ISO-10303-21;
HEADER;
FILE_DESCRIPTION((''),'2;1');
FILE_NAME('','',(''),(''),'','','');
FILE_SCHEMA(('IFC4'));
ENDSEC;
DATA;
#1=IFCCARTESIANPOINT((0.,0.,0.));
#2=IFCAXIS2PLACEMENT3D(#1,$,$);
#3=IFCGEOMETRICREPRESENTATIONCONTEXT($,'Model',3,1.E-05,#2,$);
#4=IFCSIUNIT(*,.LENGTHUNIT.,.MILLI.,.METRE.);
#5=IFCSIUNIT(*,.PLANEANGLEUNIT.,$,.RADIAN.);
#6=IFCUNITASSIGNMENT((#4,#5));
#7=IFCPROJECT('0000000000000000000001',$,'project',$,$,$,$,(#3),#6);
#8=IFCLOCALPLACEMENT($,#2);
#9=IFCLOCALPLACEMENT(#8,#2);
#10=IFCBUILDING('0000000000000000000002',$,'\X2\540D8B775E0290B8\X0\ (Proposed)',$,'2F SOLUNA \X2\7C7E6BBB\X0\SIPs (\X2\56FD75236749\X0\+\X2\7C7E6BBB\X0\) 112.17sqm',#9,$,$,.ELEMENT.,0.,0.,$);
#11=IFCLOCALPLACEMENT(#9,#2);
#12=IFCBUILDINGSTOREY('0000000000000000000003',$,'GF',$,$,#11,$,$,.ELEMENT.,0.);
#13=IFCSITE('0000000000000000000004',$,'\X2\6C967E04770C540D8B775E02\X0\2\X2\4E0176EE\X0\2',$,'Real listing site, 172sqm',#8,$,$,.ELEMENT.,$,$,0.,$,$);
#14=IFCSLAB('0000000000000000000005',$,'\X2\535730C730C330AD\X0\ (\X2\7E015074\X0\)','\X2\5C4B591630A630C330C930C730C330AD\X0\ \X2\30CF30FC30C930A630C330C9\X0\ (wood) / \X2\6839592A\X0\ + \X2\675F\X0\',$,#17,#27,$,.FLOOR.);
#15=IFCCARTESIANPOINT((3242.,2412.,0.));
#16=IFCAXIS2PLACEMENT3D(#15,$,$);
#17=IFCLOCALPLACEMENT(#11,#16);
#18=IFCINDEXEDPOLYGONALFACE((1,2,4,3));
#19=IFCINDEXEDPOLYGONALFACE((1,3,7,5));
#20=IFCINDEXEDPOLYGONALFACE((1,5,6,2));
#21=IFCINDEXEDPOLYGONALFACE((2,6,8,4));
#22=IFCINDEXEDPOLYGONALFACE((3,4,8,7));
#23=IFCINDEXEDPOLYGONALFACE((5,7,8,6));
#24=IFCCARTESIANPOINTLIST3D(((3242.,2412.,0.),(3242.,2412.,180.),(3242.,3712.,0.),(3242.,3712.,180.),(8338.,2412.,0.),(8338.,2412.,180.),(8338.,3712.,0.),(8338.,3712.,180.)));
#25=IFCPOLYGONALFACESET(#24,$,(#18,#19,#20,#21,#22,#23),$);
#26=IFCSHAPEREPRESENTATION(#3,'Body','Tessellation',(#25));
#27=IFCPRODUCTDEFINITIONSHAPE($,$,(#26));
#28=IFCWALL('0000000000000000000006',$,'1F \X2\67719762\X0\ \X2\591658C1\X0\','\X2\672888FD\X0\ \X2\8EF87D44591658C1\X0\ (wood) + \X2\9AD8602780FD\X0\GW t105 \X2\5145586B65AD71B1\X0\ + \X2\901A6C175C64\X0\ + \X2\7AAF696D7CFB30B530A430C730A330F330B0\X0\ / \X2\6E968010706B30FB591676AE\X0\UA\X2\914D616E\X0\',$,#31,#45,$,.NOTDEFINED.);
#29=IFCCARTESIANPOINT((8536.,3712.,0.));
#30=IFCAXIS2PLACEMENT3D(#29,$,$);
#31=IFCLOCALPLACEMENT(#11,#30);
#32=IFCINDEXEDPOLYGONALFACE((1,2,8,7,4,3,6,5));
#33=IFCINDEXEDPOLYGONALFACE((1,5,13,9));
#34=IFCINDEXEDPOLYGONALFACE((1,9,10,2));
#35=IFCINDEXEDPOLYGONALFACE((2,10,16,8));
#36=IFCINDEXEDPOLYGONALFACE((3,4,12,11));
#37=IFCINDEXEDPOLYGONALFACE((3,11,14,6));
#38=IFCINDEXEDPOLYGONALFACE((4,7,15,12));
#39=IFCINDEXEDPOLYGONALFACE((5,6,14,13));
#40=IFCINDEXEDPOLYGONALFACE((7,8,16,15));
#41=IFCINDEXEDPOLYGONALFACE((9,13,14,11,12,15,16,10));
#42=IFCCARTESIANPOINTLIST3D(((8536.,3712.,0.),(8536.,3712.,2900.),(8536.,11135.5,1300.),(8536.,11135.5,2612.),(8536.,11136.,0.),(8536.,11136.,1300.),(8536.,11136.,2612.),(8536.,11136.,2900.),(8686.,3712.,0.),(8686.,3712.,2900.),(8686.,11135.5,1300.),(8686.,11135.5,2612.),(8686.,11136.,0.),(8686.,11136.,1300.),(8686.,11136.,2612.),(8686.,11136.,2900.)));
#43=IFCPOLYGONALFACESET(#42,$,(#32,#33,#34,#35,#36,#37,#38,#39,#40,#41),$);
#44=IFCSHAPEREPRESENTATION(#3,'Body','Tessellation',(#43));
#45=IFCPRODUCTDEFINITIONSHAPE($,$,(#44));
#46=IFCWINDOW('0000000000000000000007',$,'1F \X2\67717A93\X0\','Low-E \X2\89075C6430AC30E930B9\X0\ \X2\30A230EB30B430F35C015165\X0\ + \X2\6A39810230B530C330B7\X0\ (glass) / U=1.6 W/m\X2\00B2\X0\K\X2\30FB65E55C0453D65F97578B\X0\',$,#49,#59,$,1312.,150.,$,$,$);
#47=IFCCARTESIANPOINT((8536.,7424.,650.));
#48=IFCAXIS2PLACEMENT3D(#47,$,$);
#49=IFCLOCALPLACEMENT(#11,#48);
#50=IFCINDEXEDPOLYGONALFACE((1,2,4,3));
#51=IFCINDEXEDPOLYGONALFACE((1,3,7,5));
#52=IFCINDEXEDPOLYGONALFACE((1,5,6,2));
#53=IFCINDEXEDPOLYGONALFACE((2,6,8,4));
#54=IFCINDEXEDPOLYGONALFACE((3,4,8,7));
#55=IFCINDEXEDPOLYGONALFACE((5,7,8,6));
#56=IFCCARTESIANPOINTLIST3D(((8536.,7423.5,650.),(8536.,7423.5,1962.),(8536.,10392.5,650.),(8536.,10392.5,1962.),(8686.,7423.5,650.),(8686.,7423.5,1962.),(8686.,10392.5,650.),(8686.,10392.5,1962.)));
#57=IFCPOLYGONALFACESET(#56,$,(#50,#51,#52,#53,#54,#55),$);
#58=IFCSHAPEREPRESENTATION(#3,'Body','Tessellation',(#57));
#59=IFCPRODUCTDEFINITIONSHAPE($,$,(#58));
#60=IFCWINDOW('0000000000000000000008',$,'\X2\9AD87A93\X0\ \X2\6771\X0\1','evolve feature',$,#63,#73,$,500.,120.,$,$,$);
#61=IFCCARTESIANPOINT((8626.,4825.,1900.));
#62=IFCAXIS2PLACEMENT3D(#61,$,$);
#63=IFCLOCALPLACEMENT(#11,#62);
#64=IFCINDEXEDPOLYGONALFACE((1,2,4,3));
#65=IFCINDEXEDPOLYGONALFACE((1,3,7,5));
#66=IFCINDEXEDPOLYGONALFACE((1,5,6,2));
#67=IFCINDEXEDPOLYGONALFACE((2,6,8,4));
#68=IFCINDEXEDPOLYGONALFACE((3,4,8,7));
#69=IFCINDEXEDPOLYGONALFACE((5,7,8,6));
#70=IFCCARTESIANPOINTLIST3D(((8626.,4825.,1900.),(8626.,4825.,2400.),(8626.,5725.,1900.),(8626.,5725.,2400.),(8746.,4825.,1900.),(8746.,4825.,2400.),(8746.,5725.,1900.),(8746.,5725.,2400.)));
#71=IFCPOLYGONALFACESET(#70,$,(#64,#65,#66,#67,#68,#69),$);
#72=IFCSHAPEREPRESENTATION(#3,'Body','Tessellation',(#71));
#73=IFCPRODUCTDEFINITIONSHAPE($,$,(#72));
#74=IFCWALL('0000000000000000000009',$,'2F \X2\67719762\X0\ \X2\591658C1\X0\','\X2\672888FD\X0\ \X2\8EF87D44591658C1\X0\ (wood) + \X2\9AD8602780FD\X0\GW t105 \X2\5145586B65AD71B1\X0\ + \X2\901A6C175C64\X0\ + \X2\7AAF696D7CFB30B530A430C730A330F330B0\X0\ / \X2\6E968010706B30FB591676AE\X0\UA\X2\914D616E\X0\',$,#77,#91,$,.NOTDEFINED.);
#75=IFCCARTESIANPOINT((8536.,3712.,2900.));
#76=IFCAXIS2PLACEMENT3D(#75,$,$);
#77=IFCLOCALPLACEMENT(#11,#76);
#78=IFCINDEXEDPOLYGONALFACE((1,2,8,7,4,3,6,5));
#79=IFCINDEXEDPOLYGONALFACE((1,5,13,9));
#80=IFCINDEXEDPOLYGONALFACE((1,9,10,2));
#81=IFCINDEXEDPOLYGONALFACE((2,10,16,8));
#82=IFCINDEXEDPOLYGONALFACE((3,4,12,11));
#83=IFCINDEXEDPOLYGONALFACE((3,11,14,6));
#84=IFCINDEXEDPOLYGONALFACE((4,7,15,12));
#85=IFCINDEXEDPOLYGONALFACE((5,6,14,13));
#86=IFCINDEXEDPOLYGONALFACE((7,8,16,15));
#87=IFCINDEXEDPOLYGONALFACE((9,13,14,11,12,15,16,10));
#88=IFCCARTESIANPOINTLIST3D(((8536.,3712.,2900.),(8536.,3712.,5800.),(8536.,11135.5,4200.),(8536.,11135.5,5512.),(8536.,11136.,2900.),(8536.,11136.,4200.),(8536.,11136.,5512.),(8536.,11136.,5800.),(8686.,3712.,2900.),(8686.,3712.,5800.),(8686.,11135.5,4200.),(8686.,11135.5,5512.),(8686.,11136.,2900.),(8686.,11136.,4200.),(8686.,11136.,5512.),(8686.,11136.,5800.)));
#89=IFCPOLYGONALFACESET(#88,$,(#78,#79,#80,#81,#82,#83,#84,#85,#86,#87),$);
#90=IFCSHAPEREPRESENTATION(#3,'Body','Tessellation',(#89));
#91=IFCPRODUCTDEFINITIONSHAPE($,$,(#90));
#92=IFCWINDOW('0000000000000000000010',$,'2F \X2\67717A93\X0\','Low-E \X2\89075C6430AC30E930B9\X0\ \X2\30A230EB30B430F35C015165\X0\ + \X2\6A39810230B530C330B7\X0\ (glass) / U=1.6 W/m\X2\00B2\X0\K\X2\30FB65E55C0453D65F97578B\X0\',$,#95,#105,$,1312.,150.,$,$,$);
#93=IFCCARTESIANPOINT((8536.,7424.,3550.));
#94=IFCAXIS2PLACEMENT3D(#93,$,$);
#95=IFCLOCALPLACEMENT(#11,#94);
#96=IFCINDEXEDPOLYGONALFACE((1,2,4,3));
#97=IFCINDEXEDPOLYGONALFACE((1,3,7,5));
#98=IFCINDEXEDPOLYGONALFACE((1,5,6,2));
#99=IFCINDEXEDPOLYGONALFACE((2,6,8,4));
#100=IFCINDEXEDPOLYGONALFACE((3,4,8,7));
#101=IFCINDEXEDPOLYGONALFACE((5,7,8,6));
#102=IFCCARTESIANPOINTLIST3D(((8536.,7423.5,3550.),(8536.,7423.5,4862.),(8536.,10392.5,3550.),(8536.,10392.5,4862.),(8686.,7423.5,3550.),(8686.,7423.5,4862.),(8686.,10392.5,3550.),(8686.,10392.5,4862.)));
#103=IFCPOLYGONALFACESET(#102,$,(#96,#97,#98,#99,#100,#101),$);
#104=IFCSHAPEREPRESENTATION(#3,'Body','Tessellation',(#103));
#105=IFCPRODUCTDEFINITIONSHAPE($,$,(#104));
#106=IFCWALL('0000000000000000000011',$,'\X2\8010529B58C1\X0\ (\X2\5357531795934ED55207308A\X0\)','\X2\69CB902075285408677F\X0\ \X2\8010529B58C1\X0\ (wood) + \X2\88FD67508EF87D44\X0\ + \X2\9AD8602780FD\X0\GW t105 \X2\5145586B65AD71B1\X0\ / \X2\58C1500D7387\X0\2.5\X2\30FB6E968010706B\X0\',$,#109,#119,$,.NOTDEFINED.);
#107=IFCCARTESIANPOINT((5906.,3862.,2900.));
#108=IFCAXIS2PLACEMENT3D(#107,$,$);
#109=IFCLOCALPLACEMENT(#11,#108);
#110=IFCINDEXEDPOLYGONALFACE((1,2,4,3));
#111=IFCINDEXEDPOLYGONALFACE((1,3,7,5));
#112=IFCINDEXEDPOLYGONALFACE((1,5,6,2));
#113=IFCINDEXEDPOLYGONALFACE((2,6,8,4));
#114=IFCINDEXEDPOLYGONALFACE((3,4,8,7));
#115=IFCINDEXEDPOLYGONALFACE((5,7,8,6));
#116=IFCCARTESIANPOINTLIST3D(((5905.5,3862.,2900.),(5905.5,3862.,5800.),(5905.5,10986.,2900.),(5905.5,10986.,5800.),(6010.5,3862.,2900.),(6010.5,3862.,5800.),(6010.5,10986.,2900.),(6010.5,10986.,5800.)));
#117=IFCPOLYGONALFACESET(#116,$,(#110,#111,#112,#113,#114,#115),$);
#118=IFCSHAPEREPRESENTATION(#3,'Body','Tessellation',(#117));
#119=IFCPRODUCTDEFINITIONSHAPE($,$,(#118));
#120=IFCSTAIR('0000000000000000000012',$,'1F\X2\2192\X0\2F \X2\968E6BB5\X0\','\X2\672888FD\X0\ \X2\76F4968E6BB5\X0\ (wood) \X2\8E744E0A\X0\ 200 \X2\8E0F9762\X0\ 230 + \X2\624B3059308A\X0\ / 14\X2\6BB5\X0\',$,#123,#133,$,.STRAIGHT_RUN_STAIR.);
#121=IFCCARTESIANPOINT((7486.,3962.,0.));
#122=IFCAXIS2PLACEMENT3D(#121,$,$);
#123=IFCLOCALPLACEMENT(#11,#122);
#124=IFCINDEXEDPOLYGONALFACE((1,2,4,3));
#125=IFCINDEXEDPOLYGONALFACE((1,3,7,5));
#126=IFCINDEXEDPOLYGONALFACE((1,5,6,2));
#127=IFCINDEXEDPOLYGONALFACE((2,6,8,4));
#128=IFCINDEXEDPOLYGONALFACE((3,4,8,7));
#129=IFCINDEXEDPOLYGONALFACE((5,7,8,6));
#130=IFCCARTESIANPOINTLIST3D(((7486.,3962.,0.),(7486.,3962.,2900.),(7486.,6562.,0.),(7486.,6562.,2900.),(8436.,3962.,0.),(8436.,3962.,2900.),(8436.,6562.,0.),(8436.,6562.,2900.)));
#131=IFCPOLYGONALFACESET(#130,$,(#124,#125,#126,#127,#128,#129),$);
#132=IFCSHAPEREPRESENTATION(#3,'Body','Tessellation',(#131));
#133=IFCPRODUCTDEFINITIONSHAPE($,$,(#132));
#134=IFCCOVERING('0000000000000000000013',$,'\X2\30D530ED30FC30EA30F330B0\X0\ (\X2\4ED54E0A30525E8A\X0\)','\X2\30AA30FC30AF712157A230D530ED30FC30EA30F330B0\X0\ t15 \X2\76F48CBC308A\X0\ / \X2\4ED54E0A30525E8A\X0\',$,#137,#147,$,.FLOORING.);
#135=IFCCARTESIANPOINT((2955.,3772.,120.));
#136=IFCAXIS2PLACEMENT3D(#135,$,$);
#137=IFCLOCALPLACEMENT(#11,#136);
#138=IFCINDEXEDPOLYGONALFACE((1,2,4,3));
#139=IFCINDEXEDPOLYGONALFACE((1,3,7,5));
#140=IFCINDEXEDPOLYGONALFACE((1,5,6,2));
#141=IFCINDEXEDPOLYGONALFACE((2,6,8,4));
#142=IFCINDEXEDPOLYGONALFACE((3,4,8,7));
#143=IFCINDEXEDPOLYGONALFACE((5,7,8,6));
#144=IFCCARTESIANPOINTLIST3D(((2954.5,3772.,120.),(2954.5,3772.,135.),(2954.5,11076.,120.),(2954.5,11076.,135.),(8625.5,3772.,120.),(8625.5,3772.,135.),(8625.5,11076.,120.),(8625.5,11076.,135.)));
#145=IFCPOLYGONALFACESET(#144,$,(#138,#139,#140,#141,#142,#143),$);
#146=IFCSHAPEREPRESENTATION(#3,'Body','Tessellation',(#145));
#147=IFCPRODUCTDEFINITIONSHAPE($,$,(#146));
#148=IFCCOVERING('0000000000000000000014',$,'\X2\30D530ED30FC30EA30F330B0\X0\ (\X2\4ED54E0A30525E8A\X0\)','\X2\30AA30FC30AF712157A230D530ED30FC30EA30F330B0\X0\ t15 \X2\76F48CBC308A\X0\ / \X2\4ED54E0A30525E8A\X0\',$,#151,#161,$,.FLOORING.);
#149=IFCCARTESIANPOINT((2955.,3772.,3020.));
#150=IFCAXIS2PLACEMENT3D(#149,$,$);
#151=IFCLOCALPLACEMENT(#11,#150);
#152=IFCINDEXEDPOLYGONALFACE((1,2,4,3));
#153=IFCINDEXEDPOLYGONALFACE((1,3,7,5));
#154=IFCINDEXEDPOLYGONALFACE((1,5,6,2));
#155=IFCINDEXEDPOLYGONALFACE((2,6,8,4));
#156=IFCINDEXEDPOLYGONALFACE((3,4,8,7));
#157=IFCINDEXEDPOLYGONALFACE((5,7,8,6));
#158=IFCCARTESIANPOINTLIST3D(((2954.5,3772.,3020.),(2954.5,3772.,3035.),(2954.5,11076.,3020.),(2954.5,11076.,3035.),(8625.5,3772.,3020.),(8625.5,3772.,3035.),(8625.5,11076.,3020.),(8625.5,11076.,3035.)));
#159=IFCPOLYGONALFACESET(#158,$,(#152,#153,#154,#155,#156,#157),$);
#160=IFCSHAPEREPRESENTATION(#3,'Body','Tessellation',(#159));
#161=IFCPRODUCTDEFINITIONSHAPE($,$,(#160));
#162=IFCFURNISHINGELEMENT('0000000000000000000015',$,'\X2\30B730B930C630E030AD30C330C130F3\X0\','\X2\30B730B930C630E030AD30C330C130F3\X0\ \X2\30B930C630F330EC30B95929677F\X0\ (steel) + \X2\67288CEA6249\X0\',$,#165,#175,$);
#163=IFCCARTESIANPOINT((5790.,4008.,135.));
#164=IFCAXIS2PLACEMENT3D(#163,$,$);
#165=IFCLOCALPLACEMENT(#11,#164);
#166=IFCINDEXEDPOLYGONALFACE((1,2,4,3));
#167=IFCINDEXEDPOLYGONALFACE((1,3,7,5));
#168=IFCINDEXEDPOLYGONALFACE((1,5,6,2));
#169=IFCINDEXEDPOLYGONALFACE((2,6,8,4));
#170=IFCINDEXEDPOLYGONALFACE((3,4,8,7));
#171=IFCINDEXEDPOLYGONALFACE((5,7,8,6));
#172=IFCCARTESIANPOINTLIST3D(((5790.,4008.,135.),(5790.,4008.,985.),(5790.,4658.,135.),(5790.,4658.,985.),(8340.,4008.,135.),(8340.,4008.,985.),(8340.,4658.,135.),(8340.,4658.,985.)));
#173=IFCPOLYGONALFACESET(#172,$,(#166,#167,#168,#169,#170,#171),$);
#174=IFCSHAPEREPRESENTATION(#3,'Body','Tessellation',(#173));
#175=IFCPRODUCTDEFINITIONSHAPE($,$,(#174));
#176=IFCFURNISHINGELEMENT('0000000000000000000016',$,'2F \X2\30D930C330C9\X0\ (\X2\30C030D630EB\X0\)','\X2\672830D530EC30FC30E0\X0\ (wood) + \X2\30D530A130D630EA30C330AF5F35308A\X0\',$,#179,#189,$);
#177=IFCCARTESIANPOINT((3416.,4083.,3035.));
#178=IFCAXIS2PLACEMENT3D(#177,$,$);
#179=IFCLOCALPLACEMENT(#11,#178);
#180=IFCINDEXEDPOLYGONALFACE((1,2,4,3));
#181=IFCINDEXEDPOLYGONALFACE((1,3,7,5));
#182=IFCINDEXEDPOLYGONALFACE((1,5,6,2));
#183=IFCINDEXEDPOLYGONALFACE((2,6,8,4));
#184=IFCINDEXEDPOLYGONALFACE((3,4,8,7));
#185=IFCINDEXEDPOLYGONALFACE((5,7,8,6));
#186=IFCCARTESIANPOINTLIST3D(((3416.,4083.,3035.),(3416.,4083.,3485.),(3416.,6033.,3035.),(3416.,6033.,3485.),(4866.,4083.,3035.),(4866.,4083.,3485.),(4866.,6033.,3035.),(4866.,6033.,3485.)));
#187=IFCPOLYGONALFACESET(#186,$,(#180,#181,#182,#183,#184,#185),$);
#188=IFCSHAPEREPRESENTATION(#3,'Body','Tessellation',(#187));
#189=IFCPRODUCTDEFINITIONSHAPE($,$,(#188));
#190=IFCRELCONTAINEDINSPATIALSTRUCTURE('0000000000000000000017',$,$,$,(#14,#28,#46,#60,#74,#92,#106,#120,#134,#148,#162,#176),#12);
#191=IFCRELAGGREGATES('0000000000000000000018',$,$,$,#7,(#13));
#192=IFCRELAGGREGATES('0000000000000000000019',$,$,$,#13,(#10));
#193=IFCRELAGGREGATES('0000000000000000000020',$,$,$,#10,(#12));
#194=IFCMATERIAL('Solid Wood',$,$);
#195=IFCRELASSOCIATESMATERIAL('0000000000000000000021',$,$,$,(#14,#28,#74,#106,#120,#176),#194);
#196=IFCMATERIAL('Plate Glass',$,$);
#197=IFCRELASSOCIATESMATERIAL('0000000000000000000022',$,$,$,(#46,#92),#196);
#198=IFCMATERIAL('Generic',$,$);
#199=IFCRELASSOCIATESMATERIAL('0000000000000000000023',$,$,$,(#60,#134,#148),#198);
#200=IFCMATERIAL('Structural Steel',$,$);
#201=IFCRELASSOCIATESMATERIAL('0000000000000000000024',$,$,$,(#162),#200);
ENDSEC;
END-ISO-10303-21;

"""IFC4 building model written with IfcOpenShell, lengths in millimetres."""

from ifc_helpers import new_model, si_unit, frame, frame_2d, origin, place, context, project, spatial, rectangle, extrude, material, element, fill, save


model = new_model("IFC4")

# Units and contexts
model_context = context("Model", 3, precision=1e-05, world=origin())
ifc_project = project(units=[si_unit("LENGTHUNIT", "METRE", prefix="MILLI"), si_unit("PLANEANGLEUNIT", "RADIAN")], contexts=[model_context])

# Site, building, storey
site_placement = place(None, origin())
site = spatial("IfcSite", under=ifc_project, at=site_placement, Name="沖縄県名護市2丁目2", ObjectType="Real listing site, 172sqm", CompositionType="ELEMENT", RefElevation=0.0)
building_placement = place(site_placement, origin())
building = spatial("IfcBuilding", under=site, at=building_placement, Name="名護市邸 (Proposed)", ObjectType="2F SOLUNA 籾殻SIPs (国産杉+籾殻) 112.17sqm", CompositionType="ELEMENT", ElevationOfRefHeight=0.0, ElevationOfTerrain=0.0)
storey_placement = place(building_placement, origin())
storey = spatial("IfcBuildingStorey", under=building, at=storey_placement, Name="GF", CompositionType="ELEMENT", Elevation=0.0)

# Slab
ifc_material_1 = material(Name="Solid Wood")
slab_placement = place(storey_placement, frame((3242.0, 2412.0, 0.0)))
element("IfcSlab", 1, at=slab_placement, inside=storey, material=ifc_material_1, Name="南デッキ (縁側)", Description="屋外ウッドデッキ ハードウッド (wood) / 根太 + 束", PredefinedType="FLOOR", context=model_context, shape_type="SweptSolid", body=[
    extrude(rectangle(XDim=5096.0, YDim=1300.0, at=frame_2d((2548.0, 650.0))), frame((3242.0, 2412.0, 0.0)), (0.0, 0.0, 1.0), 180.0),
])

# Wall, openings, windows
wall_1_placement = place(storey_placement, frame((8536.0, 3712.0, 0.0)))
wall_1 = element("IfcWall", 2, at=wall_1_placement, inside=storey, material=ifc_material_1, Name="1F 東面 外壁", Description="木製 軸組外壁 (wood) + 高性能GW t105 充填断熱 + 通気層 + 窯業系サイディング / 準耐火・外皮UA配慮", PredefinedType="NOTDEFINED", context=model_context, shape_type="SweptSolid", body=[
    extrude(rectangle(XDim=150.0, YDim=7424.0, at=frame_2d((75.0, 3712.0))), frame((8536.0, 3712.0, 0.0)), (0.0, 0.0, 1.0), 2900.0),
])
opening_1_placement = place(storey_placement, frame((8536.0, 7424.0, 650.0)))
opening_1 = element("IfcOpeningElement", 3, at=opening_1_placement, cuts=wall_1, PredefinedType="NOTDEFINED", context=model_context, shape_type="SweptSolid", body=[
    extrude(rectangle(XDim=150.0, YDim=2969.0, at=frame_2d((75.0, 1484.0))), frame((8536.0, 7424.0, 650.0)), (0.0, 0.0, 1.0), 1312.0),
])
opening_2_placement = place(storey_placement, frame((8626.0, 4825.0, 1900.0)))
opening_2 = element("IfcOpeningElement", 4, at=opening_2_placement, cuts=wall_1, PredefinedType="NOTDEFINED", context=model_context, shape_type="SweptSolid", body=[
    extrude(rectangle(XDim=120.0, YDim=900.0, at=frame_2d((60.0, 450.0))), frame((8626.0, 4825.0, 1900.0)), (0.0, 0.0, 1.0), 500.0),
])
ifc_material_2 = material(Name="Plate Glass")
window_1_placement = place(storey_placement, frame((8536.0, 7424.0, 650.0)))
window_1 = element("IfcWindow", 5, at=window_1_placement, inside=storey, material=ifc_material_2, Name="1F 東窓", Description="Low-E 複層ガラス アルゴン封入 + 樹脂サッシ (glass) / U=1.6 W/m²K・日射取得型", OverallHeight=1312.0, OverallWidth=150.0, context=model_context, shape_type="SweptSolid", body=[
    extrude(rectangle(XDim=150.0, YDim=2969.0, at=frame_2d((75.0, 1484.0))), frame((8536.0, 7424.0, 650.0)), (0.0, 0.0, 1.0), 1312.0),
])
fill(opening_1, window_1)
ifc_material_3 = material(Name="Generic")
window_2_placement = place(storey_placement, frame((8626.0, 4825.0, 1900.0)))
window_2 = element("IfcWindow", 6, at=window_2_placement, inside=storey, material=ifc_material_3, Name="高窓 東1", Description="evolve feature", OverallHeight=500.0, OverallWidth=120.0, context=model_context, shape_type="SweptSolid", body=[
    extrude(rectangle(XDim=120.0, YDim=900.0, at=frame_2d((60.0, 450.0))), frame((8626.0, 4825.0, 1900.0)), (0.0, 0.0, 1.0), 500.0),
])
fill(opening_2, window_2)

# Wall, opening, window
wall_2_placement = place(storey_placement, frame((8536.0, 3712.0, 2900.0)))
wall_2 = element("IfcWall", 7, at=wall_2_placement, inside=storey, material=ifc_material_1, Name="2F 東面 外壁", Description="木製 軸組外壁 (wood) + 高性能GW t105 充填断熱 + 通気層 + 窯業系サイディング / 準耐火・外皮UA配慮", PredefinedType="NOTDEFINED", context=model_context, shape_type="SweptSolid", body=[
    extrude(rectangle(XDim=150.0, YDim=7424.0, at=frame_2d((75.0, 3712.0))), frame((8536.0, 3712.0, 2900.0)), (0.0, 0.0, 1.0), 2900.0),
])
opening_3_placement = place(storey_placement, frame((8536.0, 7424.0, 3550.0)))
opening_3 = element("IfcOpeningElement", 8, at=opening_3_placement, cuts=wall_2, PredefinedType="NOTDEFINED", context=model_context, shape_type="SweptSolid", body=[
    extrude(rectangle(XDim=150.0, YDim=2969.0, at=frame_2d((75.0, 1484.0))), frame((8536.0, 7424.0, 3550.0)), (0.0, 0.0, 1.0), 1312.0),
])
window_3_placement = place(storey_placement, frame((8536.0, 7424.0, 3550.0)))
window_3 = element("IfcWindow", 9, at=window_3_placement, inside=storey, material=ifc_material_2, Name="2F 東窓", Description="Low-E 複層ガラス アルゴン封入 + 樹脂サッシ (glass) / U=1.6 W/m²K・日射取得型", OverallHeight=1312.0, OverallWidth=150.0, context=model_context, shape_type="SweptSolid", body=[
    extrude(rectangle(XDim=150.0, YDim=2969.0, at=frame_2d((75.0, 1484.0))), frame((8536.0, 7424.0, 3550.0)), (0.0, 0.0, 1.0), 1312.0),
])
fill(opening_3, window_3)

# Wall
wall_3_placement = place(storey_placement, frame((5906.0, 3862.0, 2900.0)))
element("IfcWall", 10, at=wall_3_placement, inside=storey, material=ifc_material_1, Name="耐力壁 (南北間仕切り)", Description="構造用合板 耐力壁 (wood) + 製材軸組 + 高性能GW t105 充填断熱 / 壁倍率2.5・準耐火", PredefinedType="NOTDEFINED", context=model_context, shape_type="SweptSolid", body=[
    extrude(rectangle(XDim=105.0, YDim=7124.0, at=frame_2d((52.0, 3562.0))), frame((5906.0, 3862.0, 2900.0)), (0.0, 0.0, 1.0), 2900.0),
])

# Stair
stair_placement = place(storey_placement, frame((7486.0, 3962.0, 0.0)))
element("IfcStair", 11, at=stair_placement, inside=storey, material=ifc_material_1, Name="1F→2F 階段", Description="木製 直階段 (wood) 蹴上 200 踏面 230 + 手すり / 14段", PredefinedType="STRAIGHT_RUN_STAIR", context=model_context, shape_type="SweptSolid", body=[
    extrude(rectangle(XDim=950.0, YDim=2600.0, at=frame_2d((475.0, 1300.0))), frame((7486.0, 3962.0, 0.0)), (0.0, 0.0, 1.0), 2900.0),
])

# Coverings
covering_1_placement = place(storey_placement, frame((2955.0, 3772.0, 120.0)))
element("IfcCovering", 12, at=covering_1_placement, inside=storey, material=ifc_material_3, Name="フローリング (仕上げ床)", Description="オーク無垢フローリング t15 直貼り / 仕上げ床", PredefinedType="FLOORING", context=model_context, shape_type="SweptSolid", body=[
    extrude(rectangle(XDim=5671.0, YDim=7304.0, at=frame_2d((2835.0, 3652.0))), frame((2955.0, 3772.0, 120.0)), (0.0, 0.0, 1.0), 15.0),
])
covering_2_placement = place(storey_placement, frame((2955.0, 3772.0, 3020.0)))
element("IfcCovering", 13, at=covering_2_placement, inside=storey, material=ifc_material_3, Name="フローリング (仕上げ床)", Description="オーク無垢フローリング t15 直貼り / 仕上げ床", PredefinedType="FLOORING", context=model_context, shape_type="SweptSolid", body=[
    extrude(rectangle(XDim=5671.0, YDim=7304.0, at=frame_2d((2835.0, 3652.0))), frame((2955.0, 3772.0, 3020.0)), (0.0, 0.0, 1.0), 15.0),
])

# Furnishing elements
ifc_material_4 = material(Name="Structural Steel")
furnishing_1_placement = place(storey_placement, frame((5790.0, 4008.0, 135.0)))
element("IfcFurnishingElement", 14, at=furnishing_1_placement, inside=storey, material=ifc_material_4, Name="システムキッチン", Description="システムキッチン ステンレス天板 (steel) + 木質扉", context=model_context, shape_type="SweptSolid", body=[
    extrude(rectangle(XDim=2550.0, YDim=650.0, at=frame_2d((1275.0, 325.0))), frame((5790.0, 4008.0, 135.0)), (0.0, 0.0, 1.0), 850.0),
])
furnishing_2_placement = place(storey_placement, frame((3416.0, 4083.0, 3035.0)))
element("IfcFurnishingElement", 15, at=furnishing_2_placement, inside=storey, material=ifc_material_1, Name="2F ベッド (ダブル)", Description="木フレーム (wood) + ファブリック張り", context=model_context, shape_type="SweptSolid", body=[
    extrude(rectangle(XDim=1450.0, YDim=1950.0, at=frame_2d((725.0, 975.0))), frame((3416.0, 4083.0, 3035.0)), (0.0, 0.0, 1.0), 450.0),
])

save(model, "model.ifc")
